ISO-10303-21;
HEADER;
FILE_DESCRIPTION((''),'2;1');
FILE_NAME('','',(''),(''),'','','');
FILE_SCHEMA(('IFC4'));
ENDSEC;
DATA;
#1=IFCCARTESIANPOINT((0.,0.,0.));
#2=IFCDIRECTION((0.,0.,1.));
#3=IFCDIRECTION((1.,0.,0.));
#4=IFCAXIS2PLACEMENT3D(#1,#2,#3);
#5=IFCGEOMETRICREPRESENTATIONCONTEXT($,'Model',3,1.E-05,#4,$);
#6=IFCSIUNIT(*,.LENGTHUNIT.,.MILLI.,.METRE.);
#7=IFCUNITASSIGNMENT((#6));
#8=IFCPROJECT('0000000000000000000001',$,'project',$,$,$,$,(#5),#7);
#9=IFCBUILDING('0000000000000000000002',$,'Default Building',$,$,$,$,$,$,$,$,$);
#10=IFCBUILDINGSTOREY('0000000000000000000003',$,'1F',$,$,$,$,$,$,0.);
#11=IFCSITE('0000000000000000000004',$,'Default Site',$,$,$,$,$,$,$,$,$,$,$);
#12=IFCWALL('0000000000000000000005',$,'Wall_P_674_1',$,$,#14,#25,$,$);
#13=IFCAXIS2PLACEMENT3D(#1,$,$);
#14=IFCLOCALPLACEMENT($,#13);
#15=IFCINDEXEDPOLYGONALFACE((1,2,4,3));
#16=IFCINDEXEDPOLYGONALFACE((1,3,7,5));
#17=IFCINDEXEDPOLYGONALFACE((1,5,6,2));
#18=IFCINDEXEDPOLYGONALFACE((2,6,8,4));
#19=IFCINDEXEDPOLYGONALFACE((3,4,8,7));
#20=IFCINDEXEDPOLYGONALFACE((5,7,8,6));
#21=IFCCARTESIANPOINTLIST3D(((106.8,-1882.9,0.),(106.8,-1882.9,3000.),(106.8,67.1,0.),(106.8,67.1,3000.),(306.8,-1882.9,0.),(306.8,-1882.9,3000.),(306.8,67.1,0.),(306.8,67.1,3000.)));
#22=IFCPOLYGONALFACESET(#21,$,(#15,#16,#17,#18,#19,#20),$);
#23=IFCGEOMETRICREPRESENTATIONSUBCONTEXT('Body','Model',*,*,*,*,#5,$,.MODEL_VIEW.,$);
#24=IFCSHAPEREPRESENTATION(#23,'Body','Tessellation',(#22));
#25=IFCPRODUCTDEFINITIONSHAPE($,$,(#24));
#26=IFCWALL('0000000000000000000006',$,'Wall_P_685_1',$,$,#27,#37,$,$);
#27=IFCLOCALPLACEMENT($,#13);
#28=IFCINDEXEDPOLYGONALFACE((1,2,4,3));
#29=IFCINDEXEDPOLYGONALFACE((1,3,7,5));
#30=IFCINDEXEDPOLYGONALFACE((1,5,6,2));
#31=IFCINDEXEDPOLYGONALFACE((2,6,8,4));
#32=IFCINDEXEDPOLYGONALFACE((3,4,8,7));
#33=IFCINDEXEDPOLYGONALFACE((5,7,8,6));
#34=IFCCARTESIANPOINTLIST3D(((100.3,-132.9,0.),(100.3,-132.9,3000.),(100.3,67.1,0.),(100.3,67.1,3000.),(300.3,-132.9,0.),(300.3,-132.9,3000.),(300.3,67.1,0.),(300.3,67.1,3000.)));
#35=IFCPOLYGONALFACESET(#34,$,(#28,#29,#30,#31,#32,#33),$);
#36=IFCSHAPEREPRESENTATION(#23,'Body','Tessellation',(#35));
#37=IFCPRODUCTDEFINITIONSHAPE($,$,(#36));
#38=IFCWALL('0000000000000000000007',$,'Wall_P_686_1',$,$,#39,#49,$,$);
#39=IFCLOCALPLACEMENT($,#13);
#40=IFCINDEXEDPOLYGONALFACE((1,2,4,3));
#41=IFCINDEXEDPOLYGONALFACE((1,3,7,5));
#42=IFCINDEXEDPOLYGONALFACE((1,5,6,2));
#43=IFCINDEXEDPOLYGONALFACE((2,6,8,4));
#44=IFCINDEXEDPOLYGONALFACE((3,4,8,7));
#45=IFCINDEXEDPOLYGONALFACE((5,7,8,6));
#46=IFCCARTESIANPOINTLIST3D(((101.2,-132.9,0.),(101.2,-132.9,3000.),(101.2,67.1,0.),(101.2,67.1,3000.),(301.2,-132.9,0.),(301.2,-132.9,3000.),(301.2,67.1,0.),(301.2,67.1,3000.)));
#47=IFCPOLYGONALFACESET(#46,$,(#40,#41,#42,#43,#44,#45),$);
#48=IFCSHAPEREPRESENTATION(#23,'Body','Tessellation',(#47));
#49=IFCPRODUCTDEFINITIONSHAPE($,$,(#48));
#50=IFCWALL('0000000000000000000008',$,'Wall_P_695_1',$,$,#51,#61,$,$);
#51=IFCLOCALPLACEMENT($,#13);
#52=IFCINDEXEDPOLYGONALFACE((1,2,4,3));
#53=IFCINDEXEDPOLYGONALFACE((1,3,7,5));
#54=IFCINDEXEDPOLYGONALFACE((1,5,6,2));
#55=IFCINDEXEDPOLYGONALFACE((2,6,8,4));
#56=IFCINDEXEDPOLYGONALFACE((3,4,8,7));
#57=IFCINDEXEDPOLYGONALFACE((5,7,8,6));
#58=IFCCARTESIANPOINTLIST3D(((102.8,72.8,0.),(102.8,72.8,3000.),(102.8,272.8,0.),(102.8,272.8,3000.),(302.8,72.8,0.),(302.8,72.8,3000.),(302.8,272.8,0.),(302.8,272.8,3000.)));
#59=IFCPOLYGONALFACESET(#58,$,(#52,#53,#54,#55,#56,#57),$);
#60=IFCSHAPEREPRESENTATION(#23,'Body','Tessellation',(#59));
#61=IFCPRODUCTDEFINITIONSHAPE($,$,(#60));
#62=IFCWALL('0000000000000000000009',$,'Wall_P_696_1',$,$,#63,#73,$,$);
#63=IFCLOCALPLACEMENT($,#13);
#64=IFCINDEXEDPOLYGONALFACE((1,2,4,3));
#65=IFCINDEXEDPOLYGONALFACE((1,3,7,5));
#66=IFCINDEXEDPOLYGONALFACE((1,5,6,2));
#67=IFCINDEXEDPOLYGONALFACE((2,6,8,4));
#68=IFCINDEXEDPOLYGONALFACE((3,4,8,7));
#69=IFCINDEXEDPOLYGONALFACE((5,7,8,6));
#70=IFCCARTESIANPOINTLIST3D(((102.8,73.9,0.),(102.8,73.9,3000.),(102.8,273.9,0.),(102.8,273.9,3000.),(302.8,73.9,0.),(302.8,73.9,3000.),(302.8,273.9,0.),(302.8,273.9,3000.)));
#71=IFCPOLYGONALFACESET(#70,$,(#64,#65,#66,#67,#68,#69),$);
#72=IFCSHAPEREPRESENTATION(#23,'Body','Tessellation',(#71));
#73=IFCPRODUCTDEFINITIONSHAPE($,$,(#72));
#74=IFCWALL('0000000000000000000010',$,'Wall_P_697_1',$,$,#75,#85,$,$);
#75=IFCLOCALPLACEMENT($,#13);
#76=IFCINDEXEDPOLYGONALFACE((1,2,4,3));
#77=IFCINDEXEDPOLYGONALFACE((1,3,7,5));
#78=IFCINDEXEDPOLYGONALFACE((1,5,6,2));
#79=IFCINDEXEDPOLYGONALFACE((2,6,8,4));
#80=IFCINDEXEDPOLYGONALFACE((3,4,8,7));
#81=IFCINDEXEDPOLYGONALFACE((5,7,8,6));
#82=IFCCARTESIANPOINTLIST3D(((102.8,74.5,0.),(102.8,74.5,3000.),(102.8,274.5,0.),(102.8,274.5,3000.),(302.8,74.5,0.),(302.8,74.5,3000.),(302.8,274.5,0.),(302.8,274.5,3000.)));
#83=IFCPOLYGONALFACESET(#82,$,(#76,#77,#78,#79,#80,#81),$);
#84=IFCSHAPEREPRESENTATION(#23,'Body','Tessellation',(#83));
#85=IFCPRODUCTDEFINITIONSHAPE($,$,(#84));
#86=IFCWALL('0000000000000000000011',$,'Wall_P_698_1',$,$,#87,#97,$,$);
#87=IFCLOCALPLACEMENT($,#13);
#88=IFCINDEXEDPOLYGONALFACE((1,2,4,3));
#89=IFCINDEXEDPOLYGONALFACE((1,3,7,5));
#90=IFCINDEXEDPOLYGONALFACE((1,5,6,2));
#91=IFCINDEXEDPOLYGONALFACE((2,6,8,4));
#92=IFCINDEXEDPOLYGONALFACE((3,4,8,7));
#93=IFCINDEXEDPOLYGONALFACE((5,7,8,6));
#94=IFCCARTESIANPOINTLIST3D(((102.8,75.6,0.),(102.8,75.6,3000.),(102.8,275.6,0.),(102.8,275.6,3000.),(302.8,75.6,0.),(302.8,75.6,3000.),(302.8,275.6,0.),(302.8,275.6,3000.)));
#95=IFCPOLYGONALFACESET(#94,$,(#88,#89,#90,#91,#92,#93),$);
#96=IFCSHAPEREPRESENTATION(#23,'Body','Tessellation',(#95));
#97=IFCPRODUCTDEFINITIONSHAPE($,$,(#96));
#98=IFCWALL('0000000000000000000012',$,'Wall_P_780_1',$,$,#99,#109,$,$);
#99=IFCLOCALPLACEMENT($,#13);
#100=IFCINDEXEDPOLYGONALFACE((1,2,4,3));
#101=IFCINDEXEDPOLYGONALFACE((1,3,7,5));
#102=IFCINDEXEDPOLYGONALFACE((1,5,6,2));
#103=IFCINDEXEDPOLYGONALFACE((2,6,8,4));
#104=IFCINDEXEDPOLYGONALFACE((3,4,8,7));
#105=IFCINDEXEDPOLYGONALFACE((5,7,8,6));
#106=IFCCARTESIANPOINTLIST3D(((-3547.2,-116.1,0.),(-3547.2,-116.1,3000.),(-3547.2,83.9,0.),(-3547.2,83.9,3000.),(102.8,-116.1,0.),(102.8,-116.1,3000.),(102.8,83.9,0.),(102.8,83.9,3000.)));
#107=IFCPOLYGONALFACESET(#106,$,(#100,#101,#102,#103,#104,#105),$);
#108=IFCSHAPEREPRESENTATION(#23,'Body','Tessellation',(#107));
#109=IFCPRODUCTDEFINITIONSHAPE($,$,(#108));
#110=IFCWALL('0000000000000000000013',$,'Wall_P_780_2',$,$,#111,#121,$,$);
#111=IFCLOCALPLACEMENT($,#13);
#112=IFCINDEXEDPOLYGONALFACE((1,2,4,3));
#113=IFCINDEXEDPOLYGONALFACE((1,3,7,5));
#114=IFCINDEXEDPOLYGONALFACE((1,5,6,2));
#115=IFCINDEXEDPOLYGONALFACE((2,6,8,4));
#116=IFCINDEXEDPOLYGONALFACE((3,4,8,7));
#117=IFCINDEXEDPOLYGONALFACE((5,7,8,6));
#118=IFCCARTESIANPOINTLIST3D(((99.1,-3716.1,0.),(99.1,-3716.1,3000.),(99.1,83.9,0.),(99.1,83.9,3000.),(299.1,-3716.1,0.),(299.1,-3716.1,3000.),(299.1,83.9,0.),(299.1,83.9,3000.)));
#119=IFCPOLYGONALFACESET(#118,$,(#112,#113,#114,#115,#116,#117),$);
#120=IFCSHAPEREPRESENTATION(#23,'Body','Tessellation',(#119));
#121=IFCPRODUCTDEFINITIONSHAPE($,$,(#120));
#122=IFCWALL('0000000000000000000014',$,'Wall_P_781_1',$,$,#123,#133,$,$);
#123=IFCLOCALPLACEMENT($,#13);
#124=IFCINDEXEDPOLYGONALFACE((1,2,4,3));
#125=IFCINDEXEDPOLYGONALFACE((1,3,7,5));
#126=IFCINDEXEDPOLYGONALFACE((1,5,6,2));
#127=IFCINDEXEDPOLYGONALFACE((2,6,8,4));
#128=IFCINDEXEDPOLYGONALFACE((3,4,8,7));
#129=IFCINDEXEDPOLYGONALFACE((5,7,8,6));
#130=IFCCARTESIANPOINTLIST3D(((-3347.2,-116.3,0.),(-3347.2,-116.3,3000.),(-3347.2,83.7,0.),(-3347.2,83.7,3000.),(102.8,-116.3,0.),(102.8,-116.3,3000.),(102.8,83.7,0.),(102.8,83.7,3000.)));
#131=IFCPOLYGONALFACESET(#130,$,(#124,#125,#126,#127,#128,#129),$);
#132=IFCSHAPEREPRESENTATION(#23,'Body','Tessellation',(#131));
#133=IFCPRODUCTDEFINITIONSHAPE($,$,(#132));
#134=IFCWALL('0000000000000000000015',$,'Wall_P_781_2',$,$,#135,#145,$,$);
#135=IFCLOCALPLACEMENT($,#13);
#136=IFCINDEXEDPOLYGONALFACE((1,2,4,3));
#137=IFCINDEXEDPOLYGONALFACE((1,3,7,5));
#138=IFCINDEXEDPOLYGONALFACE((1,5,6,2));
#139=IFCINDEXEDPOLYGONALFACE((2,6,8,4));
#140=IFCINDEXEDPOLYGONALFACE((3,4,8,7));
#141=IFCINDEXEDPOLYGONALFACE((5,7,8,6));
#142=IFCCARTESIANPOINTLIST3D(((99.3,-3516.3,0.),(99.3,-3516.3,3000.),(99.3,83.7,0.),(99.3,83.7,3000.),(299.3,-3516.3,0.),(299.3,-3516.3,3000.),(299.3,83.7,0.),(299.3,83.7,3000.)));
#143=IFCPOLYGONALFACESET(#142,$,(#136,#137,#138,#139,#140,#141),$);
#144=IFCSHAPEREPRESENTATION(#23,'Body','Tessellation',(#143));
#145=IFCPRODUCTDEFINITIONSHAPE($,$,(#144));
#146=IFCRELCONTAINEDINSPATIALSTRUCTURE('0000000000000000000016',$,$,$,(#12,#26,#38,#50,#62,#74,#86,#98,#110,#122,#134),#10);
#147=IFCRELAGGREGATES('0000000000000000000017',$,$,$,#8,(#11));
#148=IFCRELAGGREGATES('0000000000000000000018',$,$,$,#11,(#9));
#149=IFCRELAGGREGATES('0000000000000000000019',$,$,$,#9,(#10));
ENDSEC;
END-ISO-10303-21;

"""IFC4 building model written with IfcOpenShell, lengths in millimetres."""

from ifc_helpers import new_model, si_unit, frame, origin_with_axes, place, context, subcontext, project, spatial, indexed_curve, outline, extrude, element, save


model = new_model("IFC4")

# Units and contexts
model_context = context("Model", 3, precision=1e-05, world=origin_with_axes())
body_context = subcontext(model_context, "Body", "Model", "MODEL_VIEW")
ifc_project = project(units=[si_unit("LENGTHUNIT", "METRE", prefix="MILLI")], contexts=[model_context])

# Site, building, storey
site = spatial("IfcSite", under=ifc_project, Name="Default Site")
building = spatial("IfcBuilding", under=site, Name="Default Building")
storey = spatial("IfcBuildingStorey", under=building, Name="1F", Elevation=0.0)

# Walls
wall_1_placement = place(None, frame((106.8, 67.1, 0.0), z_axis=(0.0, 0.0, 1.0), x_axis=(0.0, -1.0, 0.0)))
element("IfcWall", 1, at=wall_1_placement, inside=storey, Name="Wall_P_674_1", context=body_context, shape_type="SweptSolid", body=[
    extrude(outline(indexed_curve([(0.0, 0.0), (0.0, 200.0), (1950.0, 200.0), (1950.0, 0.0), (0.0, 0.0)], self_intersect=False)), origin_with_axes(), (0.0, 0.0, 1.0), 3000.0),
])
wall_2_placement = place(None, frame((100.3, 67.1, 0.0), z_axis=(0.0, 0.0, 1.0), x_axis=(0.0, -1.0, 0.0)))
element("IfcWall", 2, at=wall_2_placement, inside=storey, Name="Wall_P_685_1", context=body_context, shape_type="SweptSolid", body=[
    extrude(outline(indexed_curve([(0.0, 0.0), (0.0, 200.0), (200.0, 200.0), (200.0, 0.0), (0.0, 0.0)], self_intersect=False)), origin_with_axes(), (0.0, 0.0, 1.0), 3000.0),
])
wall_3_placement = place(None, frame((101.2, 67.1, 0.0), z_axis=(0.0, 0.0, 1.0), x_axis=(0.0, -1.0, 0.0)))
element("IfcWall", 3, at=wall_3_placement, inside=storey, Name="Wall_P_686_1", context=body_context, shape_type="SweptSolid", body=[
    extrude(outline(indexed_curve([(0.0, 0.0), (0.0, 200.0), (200.0, 200.0), (200.0, 0.0), (0.0, 0.0)], self_intersect=False)), origin_with_axes(), (0.0, 0.0, 1.0), 3000.0),
])
wall_4_placement = place(None, frame((102.8, 72.8, 0.0), z_axis=(0.0, 0.0, 1.0), x_axis=(1.0, 0.0, 0.0)))
element("IfcWall", 4, at=wall_4_placement, inside=storey, Name="Wall_P_695_1", context=body_context, shape_type="SweptSolid", body=[
    extrude(outline(indexed_curve([(0.0, 0.0), (0.0, 200.0), (200.0, 200.0), (200.0, 0.0), (0.0, 0.0)], self_intersect=False)), origin_with_axes(), (0.0, 0.0, 1.0), 3000.0),
])
wall_5_placement = place(None, frame((102.8, 73.9, 0.0), z_axis=(0.0, 0.0, 1.0), x_axis=(1.0, 0.0, 0.0)))
element("IfcWall", 5, at=wall_5_placement, inside=storey, Name="Wall_P_696_1", context=body_context, shape_type="SweptSolid", body=[
    extrude(outline(indexed_curve([(0.0, 0.0), (0.0, 200.0), (200.0, 200.0), (200.0, 0.0), (0.0, 0.0)], self_intersect=False)), origin_with_axes(), (0.0, 0.0, 1.0), 3000.0),
])
wall_6_placement = place(None, frame((102.8, 74.5, 0.0), z_axis=(0.0, 0.0, 1.0), x_axis=(1.0, 0.0, 0.0)))
element("IfcWall", 6, at=wall_6_placement, inside=storey, Name="Wall_P_697_1", context=body_context, shape_type="SweptSolid", body=[
    extrude(outline(indexed_curve([(0.0, 0.0), (0.0, 200.0), (200.0, 200.0), (200.0, 0.0), (0.0, 0.0)], self_intersect=False)), origin_with_axes(), (0.0, 0.0, 1.0), 3000.0),
])
wall_7_placement = place(None, frame((102.8, 75.6, 0.0), z_axis=(0.0, 0.0, 1.0), x_axis=(1.0, 0.0, 0.0)))
element("IfcWall", 7, at=wall_7_placement, inside=storey, Name="Wall_P_698_1", context=body_context, shape_type="SweptSolid", body=[
    extrude(outline(indexed_curve([(0.0, 0.0), (0.0, 200.0), (200.0, 200.0), (200.0, 0.0), (0.0, 0.0)], self_intersect=False)), origin_with_axes(), (0.0, 0.0, 1.0), 3000.0),
])
wall_8_placement = place(None, frame((102.8, 83.9, 0.0), z_axis=(0.0, 0.0, 1.0), x_axis=(-1.0, 0.0, 0.0)))
element("IfcWall", 8, at=wall_8_placement, inside=storey, Name="Wall_P_780_1", context=body_context, shape_type="SweptSolid", body=[
    extrude(outline(indexed_curve([(0.0, 0.0), (0.0, 200.0), (3650.0, 200.0), (3650.0, 0.0), (0.0, 0.0)], self_intersect=False)), origin_with_axes(), (0.0, 0.0, 1.0), 3000.0),
])
wall_9_placement = place(None, frame((99.1, 83.9, 0.0), z_axis=(0.0, 0.0, 1.0), x_axis=(0.0, -1.0, 0.0)))
element("IfcWall", 9, at=wall_9_placement, inside=storey, Name="Wall_P_780_2", context=body_context, shape_type="SweptSolid", body=[
    extrude(outline(indexed_curve([(0.0, 0.0), (0.0, 200.0), (3800.0, 200.0), (3800.0, 0.0), (0.0, 0.0)], self_intersect=False)), origin_with_axes(), (0.0, 0.0, 1.0), 3000.0),
])
wall_10_placement = place(None, frame((102.8, 83.7, 0.0), z_axis=(0.0, 0.0, 1.0), x_axis=(-1.0, 0.0, 0.0)))
element("IfcWall", 10, at=wall_10_placement, inside=storey, Name="Wall_P_781_1", context=body_context, shape_type="SweptSolid", body=[
    extrude(outline(indexed_curve([(0.0, 0.0), (0.0, 200.0), (3450.0, 200.0), (3450.0, 0.0), (0.0, 0.0)], self_intersect=False)), origin_with_axes(), (0.0, 0.0, 1.0), 3000.0),
])
wall_11_placement = place(None, frame((99.3, 83.7, 0.0), z_axis=(0.0, 0.0, 1.0), x_axis=(0.0, -1.0, 0.0)))
element("IfcWall", 11, at=wall_11_placement, inside=storey, Name="Wall_P_781_2", context=body_context, shape_type="SweptSolid", body=[
    extrude(outline(indexed_curve([(0.0, 0.0), (0.0, 200.0), (3600.0, 200.0), (3600.0, 0.0), (0.0, 0.0)], self_intersect=False)), origin_with_axes(), (0.0, 0.0, 1.0), 3000.0),
])

save(model, "model.ifc")
